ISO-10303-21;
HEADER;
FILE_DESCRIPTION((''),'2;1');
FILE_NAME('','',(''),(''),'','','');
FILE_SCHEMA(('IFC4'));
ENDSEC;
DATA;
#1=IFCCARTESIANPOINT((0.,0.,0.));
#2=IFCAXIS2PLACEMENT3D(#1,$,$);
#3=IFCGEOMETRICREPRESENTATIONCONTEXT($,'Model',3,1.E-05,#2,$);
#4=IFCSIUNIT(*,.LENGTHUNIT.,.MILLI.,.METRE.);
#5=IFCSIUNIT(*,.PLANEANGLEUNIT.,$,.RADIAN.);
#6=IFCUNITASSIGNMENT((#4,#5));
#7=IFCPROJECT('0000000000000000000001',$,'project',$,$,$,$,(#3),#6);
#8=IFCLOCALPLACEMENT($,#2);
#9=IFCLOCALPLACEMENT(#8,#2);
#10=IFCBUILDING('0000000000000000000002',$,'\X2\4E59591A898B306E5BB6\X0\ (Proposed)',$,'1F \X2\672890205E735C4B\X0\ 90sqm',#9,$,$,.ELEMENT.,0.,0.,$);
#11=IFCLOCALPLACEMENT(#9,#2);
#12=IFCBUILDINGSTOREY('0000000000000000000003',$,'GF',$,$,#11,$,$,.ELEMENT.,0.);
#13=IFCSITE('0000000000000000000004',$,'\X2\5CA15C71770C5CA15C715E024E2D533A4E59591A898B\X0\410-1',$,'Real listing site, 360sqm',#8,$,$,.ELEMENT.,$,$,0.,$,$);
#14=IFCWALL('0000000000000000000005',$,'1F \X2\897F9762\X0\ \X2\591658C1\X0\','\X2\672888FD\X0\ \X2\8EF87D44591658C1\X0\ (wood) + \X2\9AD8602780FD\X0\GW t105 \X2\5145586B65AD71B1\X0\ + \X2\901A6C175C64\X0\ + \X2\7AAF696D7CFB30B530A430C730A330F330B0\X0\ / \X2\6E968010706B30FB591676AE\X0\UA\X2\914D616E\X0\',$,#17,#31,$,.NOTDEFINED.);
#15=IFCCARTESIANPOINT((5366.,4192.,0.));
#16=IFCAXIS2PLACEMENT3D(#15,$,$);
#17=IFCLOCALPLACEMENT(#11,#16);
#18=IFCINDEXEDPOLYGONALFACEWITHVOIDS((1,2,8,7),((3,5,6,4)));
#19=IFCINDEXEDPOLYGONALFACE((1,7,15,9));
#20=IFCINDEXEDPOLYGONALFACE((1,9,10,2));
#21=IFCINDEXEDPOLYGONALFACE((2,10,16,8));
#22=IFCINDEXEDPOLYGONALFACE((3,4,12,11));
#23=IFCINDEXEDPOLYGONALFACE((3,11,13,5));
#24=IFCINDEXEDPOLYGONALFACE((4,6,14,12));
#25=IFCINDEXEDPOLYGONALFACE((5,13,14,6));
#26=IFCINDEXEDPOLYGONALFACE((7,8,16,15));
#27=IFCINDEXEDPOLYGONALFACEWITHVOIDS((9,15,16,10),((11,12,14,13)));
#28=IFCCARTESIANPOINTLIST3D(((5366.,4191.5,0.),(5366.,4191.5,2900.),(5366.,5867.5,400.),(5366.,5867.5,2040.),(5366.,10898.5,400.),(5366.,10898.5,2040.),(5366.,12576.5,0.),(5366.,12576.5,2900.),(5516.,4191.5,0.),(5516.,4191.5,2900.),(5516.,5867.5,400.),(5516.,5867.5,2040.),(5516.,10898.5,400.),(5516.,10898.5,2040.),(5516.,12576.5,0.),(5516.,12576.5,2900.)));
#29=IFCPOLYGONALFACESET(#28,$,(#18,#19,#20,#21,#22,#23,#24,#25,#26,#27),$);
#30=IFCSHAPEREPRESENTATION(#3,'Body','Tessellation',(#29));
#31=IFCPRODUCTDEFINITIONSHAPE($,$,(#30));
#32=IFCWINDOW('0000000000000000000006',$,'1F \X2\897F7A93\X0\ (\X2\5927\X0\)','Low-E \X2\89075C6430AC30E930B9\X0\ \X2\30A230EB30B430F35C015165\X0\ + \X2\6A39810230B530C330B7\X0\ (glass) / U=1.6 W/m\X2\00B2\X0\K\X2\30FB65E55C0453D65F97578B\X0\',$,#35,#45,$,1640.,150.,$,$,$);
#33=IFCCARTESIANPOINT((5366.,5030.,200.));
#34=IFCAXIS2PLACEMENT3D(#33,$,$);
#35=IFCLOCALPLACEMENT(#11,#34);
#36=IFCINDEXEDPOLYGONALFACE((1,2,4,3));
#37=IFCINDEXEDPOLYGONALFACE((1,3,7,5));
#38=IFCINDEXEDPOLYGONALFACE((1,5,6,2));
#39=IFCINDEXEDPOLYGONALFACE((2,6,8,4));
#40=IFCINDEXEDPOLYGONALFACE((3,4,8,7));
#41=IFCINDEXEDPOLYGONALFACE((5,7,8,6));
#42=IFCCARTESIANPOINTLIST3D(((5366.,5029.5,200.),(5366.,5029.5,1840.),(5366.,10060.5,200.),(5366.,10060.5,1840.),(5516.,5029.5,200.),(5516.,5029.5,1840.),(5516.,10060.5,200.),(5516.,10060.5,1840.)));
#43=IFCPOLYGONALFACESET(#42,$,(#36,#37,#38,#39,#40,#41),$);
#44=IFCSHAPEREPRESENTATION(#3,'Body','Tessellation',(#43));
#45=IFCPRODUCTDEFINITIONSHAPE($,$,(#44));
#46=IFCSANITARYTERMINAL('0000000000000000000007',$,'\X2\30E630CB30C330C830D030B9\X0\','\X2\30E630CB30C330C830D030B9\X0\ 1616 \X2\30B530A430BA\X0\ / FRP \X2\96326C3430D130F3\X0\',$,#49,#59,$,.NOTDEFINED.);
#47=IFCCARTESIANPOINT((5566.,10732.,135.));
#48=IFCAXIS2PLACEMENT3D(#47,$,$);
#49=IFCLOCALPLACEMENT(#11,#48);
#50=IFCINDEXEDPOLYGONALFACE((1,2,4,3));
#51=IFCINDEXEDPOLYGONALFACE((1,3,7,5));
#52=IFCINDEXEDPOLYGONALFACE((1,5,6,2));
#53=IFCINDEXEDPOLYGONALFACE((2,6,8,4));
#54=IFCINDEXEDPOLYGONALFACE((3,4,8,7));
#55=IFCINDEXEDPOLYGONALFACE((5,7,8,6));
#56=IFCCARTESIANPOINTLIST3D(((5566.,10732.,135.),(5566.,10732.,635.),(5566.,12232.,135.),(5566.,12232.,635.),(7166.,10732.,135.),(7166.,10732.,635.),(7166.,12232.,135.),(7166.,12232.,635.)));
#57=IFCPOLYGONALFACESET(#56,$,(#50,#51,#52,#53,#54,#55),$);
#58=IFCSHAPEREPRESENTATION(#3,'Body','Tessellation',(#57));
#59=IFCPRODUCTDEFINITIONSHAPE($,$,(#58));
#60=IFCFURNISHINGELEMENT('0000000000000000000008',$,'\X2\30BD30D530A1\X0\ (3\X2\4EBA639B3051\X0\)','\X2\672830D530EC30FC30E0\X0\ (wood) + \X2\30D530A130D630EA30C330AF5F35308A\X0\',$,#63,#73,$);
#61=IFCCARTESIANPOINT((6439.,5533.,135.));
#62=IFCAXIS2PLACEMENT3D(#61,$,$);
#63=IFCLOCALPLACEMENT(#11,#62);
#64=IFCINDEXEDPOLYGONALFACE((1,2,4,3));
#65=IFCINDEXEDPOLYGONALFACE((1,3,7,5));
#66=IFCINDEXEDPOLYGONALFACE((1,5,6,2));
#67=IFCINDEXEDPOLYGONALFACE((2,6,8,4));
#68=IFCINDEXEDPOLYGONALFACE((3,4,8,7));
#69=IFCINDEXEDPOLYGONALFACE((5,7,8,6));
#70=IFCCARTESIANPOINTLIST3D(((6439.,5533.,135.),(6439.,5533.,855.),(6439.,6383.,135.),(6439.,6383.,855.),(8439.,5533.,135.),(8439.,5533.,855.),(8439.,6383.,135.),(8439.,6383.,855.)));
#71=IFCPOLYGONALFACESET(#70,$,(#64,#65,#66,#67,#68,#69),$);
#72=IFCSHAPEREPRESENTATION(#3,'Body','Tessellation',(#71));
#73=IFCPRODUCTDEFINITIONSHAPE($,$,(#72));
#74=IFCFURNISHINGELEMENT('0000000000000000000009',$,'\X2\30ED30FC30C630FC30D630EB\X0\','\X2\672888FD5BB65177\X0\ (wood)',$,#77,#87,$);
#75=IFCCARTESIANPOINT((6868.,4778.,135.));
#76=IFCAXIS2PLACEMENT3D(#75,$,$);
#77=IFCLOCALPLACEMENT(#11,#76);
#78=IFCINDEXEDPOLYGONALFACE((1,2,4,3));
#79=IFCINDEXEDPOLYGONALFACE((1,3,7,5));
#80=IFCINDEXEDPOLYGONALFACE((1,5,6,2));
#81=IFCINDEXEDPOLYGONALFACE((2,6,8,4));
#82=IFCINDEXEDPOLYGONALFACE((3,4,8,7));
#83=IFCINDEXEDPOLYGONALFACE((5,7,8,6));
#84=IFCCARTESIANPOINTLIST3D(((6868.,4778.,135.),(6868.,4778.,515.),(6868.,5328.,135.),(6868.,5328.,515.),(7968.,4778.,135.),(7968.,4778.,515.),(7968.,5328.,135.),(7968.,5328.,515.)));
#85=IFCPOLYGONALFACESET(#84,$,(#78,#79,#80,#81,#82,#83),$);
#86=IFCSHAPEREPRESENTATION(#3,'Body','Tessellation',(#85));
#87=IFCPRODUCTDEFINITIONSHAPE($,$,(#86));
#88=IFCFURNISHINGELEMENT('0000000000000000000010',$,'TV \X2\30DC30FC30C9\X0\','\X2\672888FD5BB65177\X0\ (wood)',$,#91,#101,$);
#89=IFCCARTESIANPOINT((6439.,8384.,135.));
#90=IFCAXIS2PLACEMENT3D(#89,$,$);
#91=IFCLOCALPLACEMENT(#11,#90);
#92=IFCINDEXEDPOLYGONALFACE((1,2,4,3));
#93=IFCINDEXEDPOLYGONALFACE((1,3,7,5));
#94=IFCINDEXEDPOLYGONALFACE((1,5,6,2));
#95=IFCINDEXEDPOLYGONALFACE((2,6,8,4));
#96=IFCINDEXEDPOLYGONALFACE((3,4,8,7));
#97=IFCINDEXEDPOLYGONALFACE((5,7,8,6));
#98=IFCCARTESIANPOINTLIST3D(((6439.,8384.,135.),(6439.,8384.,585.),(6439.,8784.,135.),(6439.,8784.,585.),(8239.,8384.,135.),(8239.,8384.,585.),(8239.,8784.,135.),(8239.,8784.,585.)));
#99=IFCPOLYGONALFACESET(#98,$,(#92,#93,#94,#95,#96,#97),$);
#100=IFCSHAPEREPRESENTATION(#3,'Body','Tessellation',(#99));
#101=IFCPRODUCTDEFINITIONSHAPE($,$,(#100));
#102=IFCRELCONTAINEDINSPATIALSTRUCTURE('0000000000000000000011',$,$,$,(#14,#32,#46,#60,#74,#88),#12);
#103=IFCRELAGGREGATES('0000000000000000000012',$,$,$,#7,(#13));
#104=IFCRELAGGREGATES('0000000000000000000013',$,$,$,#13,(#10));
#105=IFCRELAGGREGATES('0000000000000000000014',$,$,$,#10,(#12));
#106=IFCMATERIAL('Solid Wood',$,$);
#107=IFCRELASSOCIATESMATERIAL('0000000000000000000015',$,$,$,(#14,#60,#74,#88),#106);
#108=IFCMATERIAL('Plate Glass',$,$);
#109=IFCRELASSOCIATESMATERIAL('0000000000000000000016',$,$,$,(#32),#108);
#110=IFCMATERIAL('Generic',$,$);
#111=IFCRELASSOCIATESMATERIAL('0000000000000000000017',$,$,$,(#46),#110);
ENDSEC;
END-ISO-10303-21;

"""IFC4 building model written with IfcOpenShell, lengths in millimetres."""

from ifc_helpers import new_model, si_unit, frame, frame_2d, origin, place, context, project, spatial, rectangle, extrude, material, element, fill, save


model = new_model("IFC4")

# Units and contexts
model_context = context("Model", 3, precision=1e-05, world=origin())
ifc_project = project(units=[si_unit("LENGTHUNIT", "METRE", prefix="MILLI"), si_unit("PLANEANGLEUNIT", "RADIAN")], contexts=[model_context])

# Site, building, storey
site_placement = place(None, origin())
site = spatial("IfcSite", under=ifc_project, at=site_placement, Name="岡山県岡山市中区乙多見410-1", ObjectType="Real listing site, 360sqm", CompositionType="ELEMENT", RefElevation=0.0)
building_placement = place(site_placement, origin())
building = spatial("IfcBuilding", under=site, at=building_placement, Name="乙多見の家 (Proposed)", ObjectType="1F 木造平屋 90sqm", CompositionType="ELEMENT", ElevationOfRefHeight=0.0, ElevationOfTerrain=0.0)
storey_placement = place(building_placement, origin())
storey = spatial("IfcBuildingStorey", under=building, at=storey_placement, Name="GF", CompositionType="ELEMENT", Elevation=0.0)

# Shared definitions
ifc_material_1 = material(Name="Solid Wood")

# Shared definitions
ifc_material_2 = material(Name="Plate Glass")

# Wall, opening, window
wall_1_placement = place(storey_placement, frame((5366.0, 4192.0, 0.0)))
wall_1 = element("IfcWall", 1, at=wall_1_placement, inside=storey, material=ifc_material_1, Name="1F 西面 外壁", Description="木製 軸組外壁 (wood) + 高性能GW t105 充填断熱 + 通気層 + 窯業系サイディング / 準耐火・外皮UA配慮", PredefinedType="NOTDEFINED", context=model_context, shape_type="SweptSolid", body=[
    extrude(rectangle(XDim=150.0, YDim=8385.0, at=frame_2d((75.0, 4192.0))), frame((5366.0, 4192.0, 0.0)), (0.0, 0.0, 1.0), 2900.0),
])
opening_1_placement = place(storey_placement, frame((5366.0, 5030.0, 200.0)))
opening_1 = element("IfcOpeningElement", 2, at=opening_1_placement, cuts=wall_1, PredefinedType="NOTDEFINED", context=model_context, shape_type="SweptSolid", body=[
    extrude(rectangle(XDim=150.0, YDim=5031.0, at=frame_2d((75.0, 2515.0))), frame((5366.0, 5030.0, 200.0)), (0.0, 0.0, 1.0), 1640.0),
])
window_1_placement = place(storey_placement, frame((5366.0, 5030.0, 200.0)))
window_1 = element("IfcWindow", 3, at=window_1_placement, inside=storey, material=ifc_material_2, Name="1F 西窓 (大)", Description="Low-E 複層ガラス アルゴン封入 + 樹脂サッシ (glass) / U=1.6 W/m²K・日射取得型", OverallHeight=1640.0, OverallWidth=150.0, context=model_context, shape_type="SweptSolid", body=[
    extrude(rectangle(XDim=150.0, YDim=5031.0, at=frame_2d((75.0, 2515.0))), frame((5366.0, 5030.0, 200.0)), (0.0, 0.0, 1.0), 1640.0),
])
fill(opening_1, window_1)

# Shared definitions
ifc_material_3 = material(Name="Generic")

# Sanitary terminal
sanitary_terminal_placement = place(storey_placement, frame((5566.0, 10732.0, 135.0)))
element("IfcSanitaryTerminal", 4, at=sanitary_terminal_placement, inside=storey, material=ifc_material_3, Name="ユニットバス", Description="ユニットバス 1616 サイズ / FRP 防水パン", PredefinedType="NOTDEFINED", context=model_context, shape_type="SweptSolid", body=[
    extrude(rectangle(XDim=1600.0, YDim=1500.0, at=frame_2d((800.0, 750.0))), frame((5566.0, 10732.0, 135.0)), (0.0, 0.0, 1.0), 500.0),
])

# Furnishing elements
furnishing_1_placement = place(storey_placement, frame((6439.0, 5533.0, 135.0)))
element("IfcFurnishingElement", 5, at=furnishing_1_placement, inside=storey, material=ifc_material_1, Name="ソファ (3人掛け)", Description="木フレーム (wood) + ファブリック張り", context=model_context, shape_type="SweptSolid", body=[
    extrude(rectangle(XDim=2000.0, YDim=850.0, at=frame_2d((1000.0, 425.0))), frame((6439.0, 5533.0, 135.0)), (0.0, 0.0, 1.0), 720.0),
])
furnishing_2_placement = place(storey_placement, frame((6868.0, 4778.0, 135.0)))
element("IfcFurnishingElement", 6, at=furnishing_2_placement, inside=storey, material=ifc_material_1, Name="ローテーブル", Description="木製家具 (wood)", context=model_context, shape_type="SweptSolid", body=[
    extrude(rectangle(XDim=1100.0, YDim=550.0, at=frame_2d((550.0, 275.0))), frame((6868.0, 4778.0, 135.0)), (0.0, 0.0, 1.0), 380.0),
])
furnishing_3_placement = place(storey_placement, frame((6439.0, 8384.0, 135.0)))
element("IfcFurnishingElement", 7, at=furnishing_3_placement, inside=storey, material=ifc_material_1, Name="TV ボード", Description="木製家具 (wood)", context=model_context, shape_type="SweptSolid", body=[
    extrude(rectangle(XDim=1800.0, YDim=400.0, at=frame_2d((900.0, 200.0))), frame((6439.0, 8384.0, 135.0)), (0.0, 0.0, 1.0), 450.0),
])

save(model, "model.ifc")
